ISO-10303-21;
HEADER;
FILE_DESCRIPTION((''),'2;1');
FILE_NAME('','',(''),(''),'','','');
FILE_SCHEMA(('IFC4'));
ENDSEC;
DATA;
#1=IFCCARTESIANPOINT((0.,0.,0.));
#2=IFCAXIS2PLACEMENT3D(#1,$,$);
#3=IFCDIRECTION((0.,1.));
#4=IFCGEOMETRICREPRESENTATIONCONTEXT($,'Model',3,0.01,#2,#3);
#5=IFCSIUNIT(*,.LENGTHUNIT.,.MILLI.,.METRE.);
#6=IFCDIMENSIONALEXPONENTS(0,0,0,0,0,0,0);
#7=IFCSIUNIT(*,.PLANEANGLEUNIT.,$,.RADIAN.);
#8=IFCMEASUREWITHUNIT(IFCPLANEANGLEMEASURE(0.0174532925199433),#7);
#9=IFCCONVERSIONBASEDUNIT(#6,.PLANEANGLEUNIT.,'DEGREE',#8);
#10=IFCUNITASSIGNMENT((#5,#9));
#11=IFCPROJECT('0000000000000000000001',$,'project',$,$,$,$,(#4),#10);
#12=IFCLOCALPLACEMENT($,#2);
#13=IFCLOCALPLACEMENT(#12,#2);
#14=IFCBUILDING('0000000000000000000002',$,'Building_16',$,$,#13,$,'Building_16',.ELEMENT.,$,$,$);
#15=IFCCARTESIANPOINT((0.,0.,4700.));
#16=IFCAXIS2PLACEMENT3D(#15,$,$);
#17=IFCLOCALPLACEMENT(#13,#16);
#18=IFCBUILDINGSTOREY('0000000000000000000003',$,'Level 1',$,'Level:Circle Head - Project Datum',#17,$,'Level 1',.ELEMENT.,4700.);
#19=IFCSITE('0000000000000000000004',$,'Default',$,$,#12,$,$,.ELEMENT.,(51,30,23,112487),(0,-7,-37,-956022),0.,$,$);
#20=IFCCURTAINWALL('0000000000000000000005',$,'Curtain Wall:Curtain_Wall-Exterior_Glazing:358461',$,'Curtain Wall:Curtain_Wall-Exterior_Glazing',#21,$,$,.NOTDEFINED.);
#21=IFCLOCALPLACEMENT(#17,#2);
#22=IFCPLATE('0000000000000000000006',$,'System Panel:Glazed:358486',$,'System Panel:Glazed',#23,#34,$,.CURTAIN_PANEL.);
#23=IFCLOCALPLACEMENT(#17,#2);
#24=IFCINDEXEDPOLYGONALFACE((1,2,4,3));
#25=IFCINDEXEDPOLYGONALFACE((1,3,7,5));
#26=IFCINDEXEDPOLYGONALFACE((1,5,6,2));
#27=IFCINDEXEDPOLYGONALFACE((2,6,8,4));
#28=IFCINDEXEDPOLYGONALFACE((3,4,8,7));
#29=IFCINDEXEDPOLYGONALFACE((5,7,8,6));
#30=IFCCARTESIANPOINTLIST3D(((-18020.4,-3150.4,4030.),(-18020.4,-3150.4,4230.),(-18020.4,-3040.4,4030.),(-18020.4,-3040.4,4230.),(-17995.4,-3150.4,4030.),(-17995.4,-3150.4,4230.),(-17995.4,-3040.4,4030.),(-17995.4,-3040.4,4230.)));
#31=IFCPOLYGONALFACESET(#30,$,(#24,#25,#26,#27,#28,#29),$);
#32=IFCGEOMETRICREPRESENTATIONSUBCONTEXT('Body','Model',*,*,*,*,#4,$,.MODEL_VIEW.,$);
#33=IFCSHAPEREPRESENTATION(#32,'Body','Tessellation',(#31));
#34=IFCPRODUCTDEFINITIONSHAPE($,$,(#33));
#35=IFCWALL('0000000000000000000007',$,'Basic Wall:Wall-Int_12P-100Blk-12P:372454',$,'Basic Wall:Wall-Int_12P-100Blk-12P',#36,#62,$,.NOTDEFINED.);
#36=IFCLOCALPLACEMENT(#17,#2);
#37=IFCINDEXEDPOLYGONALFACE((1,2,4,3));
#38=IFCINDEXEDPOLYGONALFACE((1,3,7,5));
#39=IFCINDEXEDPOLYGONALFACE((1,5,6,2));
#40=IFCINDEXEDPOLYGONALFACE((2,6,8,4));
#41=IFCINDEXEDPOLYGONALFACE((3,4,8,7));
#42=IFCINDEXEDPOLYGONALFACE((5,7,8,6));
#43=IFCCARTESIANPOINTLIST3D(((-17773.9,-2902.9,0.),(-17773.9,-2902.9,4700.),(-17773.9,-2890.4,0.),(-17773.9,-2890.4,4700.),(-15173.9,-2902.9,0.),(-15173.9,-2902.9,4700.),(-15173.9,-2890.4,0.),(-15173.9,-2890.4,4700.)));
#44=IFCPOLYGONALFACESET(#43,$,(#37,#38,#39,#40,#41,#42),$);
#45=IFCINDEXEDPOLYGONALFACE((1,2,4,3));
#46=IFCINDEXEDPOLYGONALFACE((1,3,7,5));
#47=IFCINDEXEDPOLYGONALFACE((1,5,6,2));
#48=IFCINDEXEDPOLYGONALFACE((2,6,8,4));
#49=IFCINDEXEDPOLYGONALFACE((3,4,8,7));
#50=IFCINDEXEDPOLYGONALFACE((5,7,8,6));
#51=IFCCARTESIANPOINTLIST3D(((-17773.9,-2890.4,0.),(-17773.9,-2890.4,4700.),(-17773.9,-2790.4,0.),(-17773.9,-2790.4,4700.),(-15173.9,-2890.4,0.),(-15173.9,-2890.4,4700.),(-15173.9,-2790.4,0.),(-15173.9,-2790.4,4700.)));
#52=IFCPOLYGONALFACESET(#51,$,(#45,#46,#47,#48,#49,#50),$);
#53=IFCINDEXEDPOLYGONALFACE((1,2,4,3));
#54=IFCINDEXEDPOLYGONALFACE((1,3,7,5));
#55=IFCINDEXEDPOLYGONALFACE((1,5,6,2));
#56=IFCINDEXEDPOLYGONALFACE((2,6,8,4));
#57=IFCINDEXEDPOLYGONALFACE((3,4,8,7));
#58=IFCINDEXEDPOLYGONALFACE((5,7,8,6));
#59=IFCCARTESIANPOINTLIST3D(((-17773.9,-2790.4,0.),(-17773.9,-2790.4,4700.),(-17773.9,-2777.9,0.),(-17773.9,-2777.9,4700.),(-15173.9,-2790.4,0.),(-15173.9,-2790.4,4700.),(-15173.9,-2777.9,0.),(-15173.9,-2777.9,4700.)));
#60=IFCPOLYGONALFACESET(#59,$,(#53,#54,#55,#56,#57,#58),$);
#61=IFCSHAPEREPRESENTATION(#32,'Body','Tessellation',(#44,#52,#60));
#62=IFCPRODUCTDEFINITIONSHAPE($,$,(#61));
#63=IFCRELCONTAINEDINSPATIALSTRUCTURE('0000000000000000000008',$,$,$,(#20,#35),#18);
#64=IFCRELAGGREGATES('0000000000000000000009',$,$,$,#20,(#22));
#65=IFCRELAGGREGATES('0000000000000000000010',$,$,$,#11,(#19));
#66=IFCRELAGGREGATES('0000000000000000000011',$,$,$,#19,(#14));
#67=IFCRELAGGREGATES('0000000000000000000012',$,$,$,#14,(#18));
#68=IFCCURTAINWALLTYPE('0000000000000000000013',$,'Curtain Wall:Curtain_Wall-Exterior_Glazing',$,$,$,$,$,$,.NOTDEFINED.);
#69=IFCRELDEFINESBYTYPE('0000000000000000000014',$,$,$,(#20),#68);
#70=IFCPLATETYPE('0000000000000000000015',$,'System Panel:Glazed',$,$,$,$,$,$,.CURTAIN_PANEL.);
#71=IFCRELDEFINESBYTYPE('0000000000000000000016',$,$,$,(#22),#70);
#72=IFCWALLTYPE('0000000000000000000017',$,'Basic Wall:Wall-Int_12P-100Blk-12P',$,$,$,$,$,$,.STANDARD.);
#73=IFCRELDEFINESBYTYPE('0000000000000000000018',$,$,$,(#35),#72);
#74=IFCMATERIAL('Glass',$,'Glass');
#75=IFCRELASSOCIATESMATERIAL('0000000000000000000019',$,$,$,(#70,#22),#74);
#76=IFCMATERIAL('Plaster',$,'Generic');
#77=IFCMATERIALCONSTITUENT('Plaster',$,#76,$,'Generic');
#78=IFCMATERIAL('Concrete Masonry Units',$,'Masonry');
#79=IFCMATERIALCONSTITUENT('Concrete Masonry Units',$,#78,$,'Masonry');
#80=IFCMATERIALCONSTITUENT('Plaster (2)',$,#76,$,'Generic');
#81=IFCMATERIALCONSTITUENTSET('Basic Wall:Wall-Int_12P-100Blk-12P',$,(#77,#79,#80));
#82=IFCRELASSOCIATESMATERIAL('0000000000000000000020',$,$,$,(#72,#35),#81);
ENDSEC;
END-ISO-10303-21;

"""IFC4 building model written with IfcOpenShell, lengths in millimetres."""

from ifc_helpers import new_model, entity, si_unit, converted_unit, direction, frame, origin, place, context, subcontext, project, spatial, indexed_curve, outline, extrude, source, transform, mapped, material, constituent, constituent_set, type_object, type_shapes, element, aggregate, save


model = new_model("IFC4")

# Units and contexts
model_context = context("Model", 3, precision=0.01, world=origin(), true_north=direction((0.0, 1.0)))
body_context = subcontext(model_context, "Body", "Model", "MODEL_VIEW")
ifc_project = project(units=[si_unit("LENGTHUNIT", "METRE", prefix="MILLI"), converted_unit("PLANEANGLEUNIT", "DEGREE", entity("IfcPlaneAngleMeasure", 0.0174532925199433), si_unit("PLANEANGLEUNIT", "RADIAN"), dimensions=[0, 0, 0, 0, 0, 0, 0])], contexts=[model_context])

# Site, building, storey
site_placement = place(None, origin())
site = spatial("IfcSite", under=ifc_project, at=site_placement, Name="Default", CompositionType="ELEMENT", RefLatitude=(51, 30, 23, 112487), RefLongitude=(0, -7, -37, -956022), RefElevation=0.0)
building_placement = place(site_placement, origin())
building = spatial("IfcBuilding", under=site, at=building_placement, Name="Building_16", LongName="Building_16", CompositionType="ELEMENT")
storey_placement = place(building_placement, frame((0.0, 0.0, 4700.0)))
storey = spatial("IfcBuildingStorey", under=building, at=storey_placement, Name="Level 1", ObjectType="Level:Circle Head - Project Datum", LongName="Level 1", CompositionType="ELEMENT", Elevation=4700.0)

# Curtain wall
curtain_wall_type = type_object("IfcCurtainWallType", Name="Curtain Wall:Curtain_Wall-Exterior_Glazing", PredefinedType="NOTDEFINED")
curtain_wall_1_placement = place(storey_placement, frame((0.0, 0.0, -4700.0)))
curtain_wall_1 = element("IfcCurtainWall", 1, at=curtain_wall_1_placement, inside=storey, type_object=curtain_wall_type, Name="Curtain Wall:Curtain_Wall-Exterior_Glazing:358461", ObjectType="Curtain Wall:Curtain_Wall-Exterior_Glazing", PredefinedType="NOTDEFINED")
ifc_material_1 = material(Name="Glass", Category="Glass")

# Plate
plate_type_1 = type_object("IfcPlateType", Name="System Panel:Glazed", PredefinedType="CURTAIN_PANEL", material=ifc_material_1)
shared_shape_1 = source(origin(), body_context, "Body", "SweptSolid", [
    extrude(outline(indexed_curve([(-12.5, -55.0), (12.5, -55.0), (12.5, 55.0), (-12.5, 55.0), (-12.5, -55.0)], self_intersect=False)), frame((0.0, 37.0, 0.0), z_axis=(0.0, 0.0, 1.0), x_axis=(0.0, 1.0, 0.0)), (0.0, 0.0, 1.0), 200.0),
])
type_shapes(plate_type_1, [shared_shape_1])
plate_1_placement = place(curtain_wall_1_placement, frame((-17970.9, -3095.4, 8730.0), z_axis=(0.0, 0.0, 1.0), x_axis=(0.0, 1.0, 0.0)))
plate_1 = element("IfcPlate", 2, at=plate_1_placement, type_object=plate_type_1, material=ifc_material_1, Name="System Panel:Glazed:358486", ObjectType="System Panel:Glazed", PredefinedType="CURTAIN_PANEL", context=body_context, shape_type="MappedRepresentation", body=[
    mapped(shared_shape_1, transform((0.0, 0.0, 0.0), scale=1.0)),
])
aggregate(curtain_wall_1, [plate_1])

# Wall
ifc_material_2 = material(Name="Plaster", Category="Generic")
ifc_constituent_1 = constituent(ifc_material_2, Name="Plaster", Category="Generic")
ifc_material_3 = material(Name="Concrete Masonry Units", Category="Masonry")
ifc_constituent_2 = constituent(ifc_material_3, Name="Concrete Masonry Units", Category="Masonry")
ifc_constituent_3 = constituent(ifc_material_2, Name="Plaster (2)", Category="Generic")
ifc_constituent_set = constituent_set(constituents=[ifc_constituent_1, ifc_constituent_2, ifc_constituent_3], Name="Basic Wall:Wall-Int_12P-100Blk-12P")
wall_type = type_object("IfcWallType", Name="Basic Wall:Wall-Int_12P-100Blk-12P", PredefinedType="STANDARD", material=ifc_constituent_set)
wall_placement = place(storey_placement, frame((-17773.9, -2840.4, 0.0)))
element("IfcWall", 3, at=wall_placement, inside=storey, type_object=wall_type, material=ifc_constituent_set, Name="Basic Wall:Wall-Int_12P-100Blk-12P:372454", ObjectType="Basic Wall:Wall-Int_12P-100Blk-12P", PredefinedType="NOTDEFINED", context=body_context, shape_type="SweptSolid", body=[
    extrude(outline(indexed_curve([(-6.3, -1300.0), (6.2, -1300.0), (6.3, 1300.0), (-6.2, 1300.0), (-6.3, -1300.0)], self_intersect=False)), frame((1300.0, -56.3, 0.0), z_axis=(0.0, 0.0, 1.0), x_axis=(0.0, 1.0, 0.0)), (0.0, 0.0, 1.0), 4700.0),
    extrude(outline(indexed_curve([(-1300.0, -50.0), (1300.0, -50.0), (1300.0, 50.0), (-1300.0, 50.0), (-1300.0, -50.0)], self_intersect=False)), frame((1300.0, 0.0, 0.0)), (0.0, 0.0, 1.0), 4700.0),
    extrude(outline(indexed_curve([(-6.3, -1300.0), (6.2, -1300.0), (6.3, 1300.0), (-6.2, 1300.0), (-6.3, -1300.0)], self_intersect=False)), frame((1300.0, 56.2, 0.0), z_axis=(0.0, 0.0, 1.0), x_axis=(0.0, -1.0, 0.0)), (0.0, 0.0, 1.0), 4700.0),
])

save(model, "model.ifc")
